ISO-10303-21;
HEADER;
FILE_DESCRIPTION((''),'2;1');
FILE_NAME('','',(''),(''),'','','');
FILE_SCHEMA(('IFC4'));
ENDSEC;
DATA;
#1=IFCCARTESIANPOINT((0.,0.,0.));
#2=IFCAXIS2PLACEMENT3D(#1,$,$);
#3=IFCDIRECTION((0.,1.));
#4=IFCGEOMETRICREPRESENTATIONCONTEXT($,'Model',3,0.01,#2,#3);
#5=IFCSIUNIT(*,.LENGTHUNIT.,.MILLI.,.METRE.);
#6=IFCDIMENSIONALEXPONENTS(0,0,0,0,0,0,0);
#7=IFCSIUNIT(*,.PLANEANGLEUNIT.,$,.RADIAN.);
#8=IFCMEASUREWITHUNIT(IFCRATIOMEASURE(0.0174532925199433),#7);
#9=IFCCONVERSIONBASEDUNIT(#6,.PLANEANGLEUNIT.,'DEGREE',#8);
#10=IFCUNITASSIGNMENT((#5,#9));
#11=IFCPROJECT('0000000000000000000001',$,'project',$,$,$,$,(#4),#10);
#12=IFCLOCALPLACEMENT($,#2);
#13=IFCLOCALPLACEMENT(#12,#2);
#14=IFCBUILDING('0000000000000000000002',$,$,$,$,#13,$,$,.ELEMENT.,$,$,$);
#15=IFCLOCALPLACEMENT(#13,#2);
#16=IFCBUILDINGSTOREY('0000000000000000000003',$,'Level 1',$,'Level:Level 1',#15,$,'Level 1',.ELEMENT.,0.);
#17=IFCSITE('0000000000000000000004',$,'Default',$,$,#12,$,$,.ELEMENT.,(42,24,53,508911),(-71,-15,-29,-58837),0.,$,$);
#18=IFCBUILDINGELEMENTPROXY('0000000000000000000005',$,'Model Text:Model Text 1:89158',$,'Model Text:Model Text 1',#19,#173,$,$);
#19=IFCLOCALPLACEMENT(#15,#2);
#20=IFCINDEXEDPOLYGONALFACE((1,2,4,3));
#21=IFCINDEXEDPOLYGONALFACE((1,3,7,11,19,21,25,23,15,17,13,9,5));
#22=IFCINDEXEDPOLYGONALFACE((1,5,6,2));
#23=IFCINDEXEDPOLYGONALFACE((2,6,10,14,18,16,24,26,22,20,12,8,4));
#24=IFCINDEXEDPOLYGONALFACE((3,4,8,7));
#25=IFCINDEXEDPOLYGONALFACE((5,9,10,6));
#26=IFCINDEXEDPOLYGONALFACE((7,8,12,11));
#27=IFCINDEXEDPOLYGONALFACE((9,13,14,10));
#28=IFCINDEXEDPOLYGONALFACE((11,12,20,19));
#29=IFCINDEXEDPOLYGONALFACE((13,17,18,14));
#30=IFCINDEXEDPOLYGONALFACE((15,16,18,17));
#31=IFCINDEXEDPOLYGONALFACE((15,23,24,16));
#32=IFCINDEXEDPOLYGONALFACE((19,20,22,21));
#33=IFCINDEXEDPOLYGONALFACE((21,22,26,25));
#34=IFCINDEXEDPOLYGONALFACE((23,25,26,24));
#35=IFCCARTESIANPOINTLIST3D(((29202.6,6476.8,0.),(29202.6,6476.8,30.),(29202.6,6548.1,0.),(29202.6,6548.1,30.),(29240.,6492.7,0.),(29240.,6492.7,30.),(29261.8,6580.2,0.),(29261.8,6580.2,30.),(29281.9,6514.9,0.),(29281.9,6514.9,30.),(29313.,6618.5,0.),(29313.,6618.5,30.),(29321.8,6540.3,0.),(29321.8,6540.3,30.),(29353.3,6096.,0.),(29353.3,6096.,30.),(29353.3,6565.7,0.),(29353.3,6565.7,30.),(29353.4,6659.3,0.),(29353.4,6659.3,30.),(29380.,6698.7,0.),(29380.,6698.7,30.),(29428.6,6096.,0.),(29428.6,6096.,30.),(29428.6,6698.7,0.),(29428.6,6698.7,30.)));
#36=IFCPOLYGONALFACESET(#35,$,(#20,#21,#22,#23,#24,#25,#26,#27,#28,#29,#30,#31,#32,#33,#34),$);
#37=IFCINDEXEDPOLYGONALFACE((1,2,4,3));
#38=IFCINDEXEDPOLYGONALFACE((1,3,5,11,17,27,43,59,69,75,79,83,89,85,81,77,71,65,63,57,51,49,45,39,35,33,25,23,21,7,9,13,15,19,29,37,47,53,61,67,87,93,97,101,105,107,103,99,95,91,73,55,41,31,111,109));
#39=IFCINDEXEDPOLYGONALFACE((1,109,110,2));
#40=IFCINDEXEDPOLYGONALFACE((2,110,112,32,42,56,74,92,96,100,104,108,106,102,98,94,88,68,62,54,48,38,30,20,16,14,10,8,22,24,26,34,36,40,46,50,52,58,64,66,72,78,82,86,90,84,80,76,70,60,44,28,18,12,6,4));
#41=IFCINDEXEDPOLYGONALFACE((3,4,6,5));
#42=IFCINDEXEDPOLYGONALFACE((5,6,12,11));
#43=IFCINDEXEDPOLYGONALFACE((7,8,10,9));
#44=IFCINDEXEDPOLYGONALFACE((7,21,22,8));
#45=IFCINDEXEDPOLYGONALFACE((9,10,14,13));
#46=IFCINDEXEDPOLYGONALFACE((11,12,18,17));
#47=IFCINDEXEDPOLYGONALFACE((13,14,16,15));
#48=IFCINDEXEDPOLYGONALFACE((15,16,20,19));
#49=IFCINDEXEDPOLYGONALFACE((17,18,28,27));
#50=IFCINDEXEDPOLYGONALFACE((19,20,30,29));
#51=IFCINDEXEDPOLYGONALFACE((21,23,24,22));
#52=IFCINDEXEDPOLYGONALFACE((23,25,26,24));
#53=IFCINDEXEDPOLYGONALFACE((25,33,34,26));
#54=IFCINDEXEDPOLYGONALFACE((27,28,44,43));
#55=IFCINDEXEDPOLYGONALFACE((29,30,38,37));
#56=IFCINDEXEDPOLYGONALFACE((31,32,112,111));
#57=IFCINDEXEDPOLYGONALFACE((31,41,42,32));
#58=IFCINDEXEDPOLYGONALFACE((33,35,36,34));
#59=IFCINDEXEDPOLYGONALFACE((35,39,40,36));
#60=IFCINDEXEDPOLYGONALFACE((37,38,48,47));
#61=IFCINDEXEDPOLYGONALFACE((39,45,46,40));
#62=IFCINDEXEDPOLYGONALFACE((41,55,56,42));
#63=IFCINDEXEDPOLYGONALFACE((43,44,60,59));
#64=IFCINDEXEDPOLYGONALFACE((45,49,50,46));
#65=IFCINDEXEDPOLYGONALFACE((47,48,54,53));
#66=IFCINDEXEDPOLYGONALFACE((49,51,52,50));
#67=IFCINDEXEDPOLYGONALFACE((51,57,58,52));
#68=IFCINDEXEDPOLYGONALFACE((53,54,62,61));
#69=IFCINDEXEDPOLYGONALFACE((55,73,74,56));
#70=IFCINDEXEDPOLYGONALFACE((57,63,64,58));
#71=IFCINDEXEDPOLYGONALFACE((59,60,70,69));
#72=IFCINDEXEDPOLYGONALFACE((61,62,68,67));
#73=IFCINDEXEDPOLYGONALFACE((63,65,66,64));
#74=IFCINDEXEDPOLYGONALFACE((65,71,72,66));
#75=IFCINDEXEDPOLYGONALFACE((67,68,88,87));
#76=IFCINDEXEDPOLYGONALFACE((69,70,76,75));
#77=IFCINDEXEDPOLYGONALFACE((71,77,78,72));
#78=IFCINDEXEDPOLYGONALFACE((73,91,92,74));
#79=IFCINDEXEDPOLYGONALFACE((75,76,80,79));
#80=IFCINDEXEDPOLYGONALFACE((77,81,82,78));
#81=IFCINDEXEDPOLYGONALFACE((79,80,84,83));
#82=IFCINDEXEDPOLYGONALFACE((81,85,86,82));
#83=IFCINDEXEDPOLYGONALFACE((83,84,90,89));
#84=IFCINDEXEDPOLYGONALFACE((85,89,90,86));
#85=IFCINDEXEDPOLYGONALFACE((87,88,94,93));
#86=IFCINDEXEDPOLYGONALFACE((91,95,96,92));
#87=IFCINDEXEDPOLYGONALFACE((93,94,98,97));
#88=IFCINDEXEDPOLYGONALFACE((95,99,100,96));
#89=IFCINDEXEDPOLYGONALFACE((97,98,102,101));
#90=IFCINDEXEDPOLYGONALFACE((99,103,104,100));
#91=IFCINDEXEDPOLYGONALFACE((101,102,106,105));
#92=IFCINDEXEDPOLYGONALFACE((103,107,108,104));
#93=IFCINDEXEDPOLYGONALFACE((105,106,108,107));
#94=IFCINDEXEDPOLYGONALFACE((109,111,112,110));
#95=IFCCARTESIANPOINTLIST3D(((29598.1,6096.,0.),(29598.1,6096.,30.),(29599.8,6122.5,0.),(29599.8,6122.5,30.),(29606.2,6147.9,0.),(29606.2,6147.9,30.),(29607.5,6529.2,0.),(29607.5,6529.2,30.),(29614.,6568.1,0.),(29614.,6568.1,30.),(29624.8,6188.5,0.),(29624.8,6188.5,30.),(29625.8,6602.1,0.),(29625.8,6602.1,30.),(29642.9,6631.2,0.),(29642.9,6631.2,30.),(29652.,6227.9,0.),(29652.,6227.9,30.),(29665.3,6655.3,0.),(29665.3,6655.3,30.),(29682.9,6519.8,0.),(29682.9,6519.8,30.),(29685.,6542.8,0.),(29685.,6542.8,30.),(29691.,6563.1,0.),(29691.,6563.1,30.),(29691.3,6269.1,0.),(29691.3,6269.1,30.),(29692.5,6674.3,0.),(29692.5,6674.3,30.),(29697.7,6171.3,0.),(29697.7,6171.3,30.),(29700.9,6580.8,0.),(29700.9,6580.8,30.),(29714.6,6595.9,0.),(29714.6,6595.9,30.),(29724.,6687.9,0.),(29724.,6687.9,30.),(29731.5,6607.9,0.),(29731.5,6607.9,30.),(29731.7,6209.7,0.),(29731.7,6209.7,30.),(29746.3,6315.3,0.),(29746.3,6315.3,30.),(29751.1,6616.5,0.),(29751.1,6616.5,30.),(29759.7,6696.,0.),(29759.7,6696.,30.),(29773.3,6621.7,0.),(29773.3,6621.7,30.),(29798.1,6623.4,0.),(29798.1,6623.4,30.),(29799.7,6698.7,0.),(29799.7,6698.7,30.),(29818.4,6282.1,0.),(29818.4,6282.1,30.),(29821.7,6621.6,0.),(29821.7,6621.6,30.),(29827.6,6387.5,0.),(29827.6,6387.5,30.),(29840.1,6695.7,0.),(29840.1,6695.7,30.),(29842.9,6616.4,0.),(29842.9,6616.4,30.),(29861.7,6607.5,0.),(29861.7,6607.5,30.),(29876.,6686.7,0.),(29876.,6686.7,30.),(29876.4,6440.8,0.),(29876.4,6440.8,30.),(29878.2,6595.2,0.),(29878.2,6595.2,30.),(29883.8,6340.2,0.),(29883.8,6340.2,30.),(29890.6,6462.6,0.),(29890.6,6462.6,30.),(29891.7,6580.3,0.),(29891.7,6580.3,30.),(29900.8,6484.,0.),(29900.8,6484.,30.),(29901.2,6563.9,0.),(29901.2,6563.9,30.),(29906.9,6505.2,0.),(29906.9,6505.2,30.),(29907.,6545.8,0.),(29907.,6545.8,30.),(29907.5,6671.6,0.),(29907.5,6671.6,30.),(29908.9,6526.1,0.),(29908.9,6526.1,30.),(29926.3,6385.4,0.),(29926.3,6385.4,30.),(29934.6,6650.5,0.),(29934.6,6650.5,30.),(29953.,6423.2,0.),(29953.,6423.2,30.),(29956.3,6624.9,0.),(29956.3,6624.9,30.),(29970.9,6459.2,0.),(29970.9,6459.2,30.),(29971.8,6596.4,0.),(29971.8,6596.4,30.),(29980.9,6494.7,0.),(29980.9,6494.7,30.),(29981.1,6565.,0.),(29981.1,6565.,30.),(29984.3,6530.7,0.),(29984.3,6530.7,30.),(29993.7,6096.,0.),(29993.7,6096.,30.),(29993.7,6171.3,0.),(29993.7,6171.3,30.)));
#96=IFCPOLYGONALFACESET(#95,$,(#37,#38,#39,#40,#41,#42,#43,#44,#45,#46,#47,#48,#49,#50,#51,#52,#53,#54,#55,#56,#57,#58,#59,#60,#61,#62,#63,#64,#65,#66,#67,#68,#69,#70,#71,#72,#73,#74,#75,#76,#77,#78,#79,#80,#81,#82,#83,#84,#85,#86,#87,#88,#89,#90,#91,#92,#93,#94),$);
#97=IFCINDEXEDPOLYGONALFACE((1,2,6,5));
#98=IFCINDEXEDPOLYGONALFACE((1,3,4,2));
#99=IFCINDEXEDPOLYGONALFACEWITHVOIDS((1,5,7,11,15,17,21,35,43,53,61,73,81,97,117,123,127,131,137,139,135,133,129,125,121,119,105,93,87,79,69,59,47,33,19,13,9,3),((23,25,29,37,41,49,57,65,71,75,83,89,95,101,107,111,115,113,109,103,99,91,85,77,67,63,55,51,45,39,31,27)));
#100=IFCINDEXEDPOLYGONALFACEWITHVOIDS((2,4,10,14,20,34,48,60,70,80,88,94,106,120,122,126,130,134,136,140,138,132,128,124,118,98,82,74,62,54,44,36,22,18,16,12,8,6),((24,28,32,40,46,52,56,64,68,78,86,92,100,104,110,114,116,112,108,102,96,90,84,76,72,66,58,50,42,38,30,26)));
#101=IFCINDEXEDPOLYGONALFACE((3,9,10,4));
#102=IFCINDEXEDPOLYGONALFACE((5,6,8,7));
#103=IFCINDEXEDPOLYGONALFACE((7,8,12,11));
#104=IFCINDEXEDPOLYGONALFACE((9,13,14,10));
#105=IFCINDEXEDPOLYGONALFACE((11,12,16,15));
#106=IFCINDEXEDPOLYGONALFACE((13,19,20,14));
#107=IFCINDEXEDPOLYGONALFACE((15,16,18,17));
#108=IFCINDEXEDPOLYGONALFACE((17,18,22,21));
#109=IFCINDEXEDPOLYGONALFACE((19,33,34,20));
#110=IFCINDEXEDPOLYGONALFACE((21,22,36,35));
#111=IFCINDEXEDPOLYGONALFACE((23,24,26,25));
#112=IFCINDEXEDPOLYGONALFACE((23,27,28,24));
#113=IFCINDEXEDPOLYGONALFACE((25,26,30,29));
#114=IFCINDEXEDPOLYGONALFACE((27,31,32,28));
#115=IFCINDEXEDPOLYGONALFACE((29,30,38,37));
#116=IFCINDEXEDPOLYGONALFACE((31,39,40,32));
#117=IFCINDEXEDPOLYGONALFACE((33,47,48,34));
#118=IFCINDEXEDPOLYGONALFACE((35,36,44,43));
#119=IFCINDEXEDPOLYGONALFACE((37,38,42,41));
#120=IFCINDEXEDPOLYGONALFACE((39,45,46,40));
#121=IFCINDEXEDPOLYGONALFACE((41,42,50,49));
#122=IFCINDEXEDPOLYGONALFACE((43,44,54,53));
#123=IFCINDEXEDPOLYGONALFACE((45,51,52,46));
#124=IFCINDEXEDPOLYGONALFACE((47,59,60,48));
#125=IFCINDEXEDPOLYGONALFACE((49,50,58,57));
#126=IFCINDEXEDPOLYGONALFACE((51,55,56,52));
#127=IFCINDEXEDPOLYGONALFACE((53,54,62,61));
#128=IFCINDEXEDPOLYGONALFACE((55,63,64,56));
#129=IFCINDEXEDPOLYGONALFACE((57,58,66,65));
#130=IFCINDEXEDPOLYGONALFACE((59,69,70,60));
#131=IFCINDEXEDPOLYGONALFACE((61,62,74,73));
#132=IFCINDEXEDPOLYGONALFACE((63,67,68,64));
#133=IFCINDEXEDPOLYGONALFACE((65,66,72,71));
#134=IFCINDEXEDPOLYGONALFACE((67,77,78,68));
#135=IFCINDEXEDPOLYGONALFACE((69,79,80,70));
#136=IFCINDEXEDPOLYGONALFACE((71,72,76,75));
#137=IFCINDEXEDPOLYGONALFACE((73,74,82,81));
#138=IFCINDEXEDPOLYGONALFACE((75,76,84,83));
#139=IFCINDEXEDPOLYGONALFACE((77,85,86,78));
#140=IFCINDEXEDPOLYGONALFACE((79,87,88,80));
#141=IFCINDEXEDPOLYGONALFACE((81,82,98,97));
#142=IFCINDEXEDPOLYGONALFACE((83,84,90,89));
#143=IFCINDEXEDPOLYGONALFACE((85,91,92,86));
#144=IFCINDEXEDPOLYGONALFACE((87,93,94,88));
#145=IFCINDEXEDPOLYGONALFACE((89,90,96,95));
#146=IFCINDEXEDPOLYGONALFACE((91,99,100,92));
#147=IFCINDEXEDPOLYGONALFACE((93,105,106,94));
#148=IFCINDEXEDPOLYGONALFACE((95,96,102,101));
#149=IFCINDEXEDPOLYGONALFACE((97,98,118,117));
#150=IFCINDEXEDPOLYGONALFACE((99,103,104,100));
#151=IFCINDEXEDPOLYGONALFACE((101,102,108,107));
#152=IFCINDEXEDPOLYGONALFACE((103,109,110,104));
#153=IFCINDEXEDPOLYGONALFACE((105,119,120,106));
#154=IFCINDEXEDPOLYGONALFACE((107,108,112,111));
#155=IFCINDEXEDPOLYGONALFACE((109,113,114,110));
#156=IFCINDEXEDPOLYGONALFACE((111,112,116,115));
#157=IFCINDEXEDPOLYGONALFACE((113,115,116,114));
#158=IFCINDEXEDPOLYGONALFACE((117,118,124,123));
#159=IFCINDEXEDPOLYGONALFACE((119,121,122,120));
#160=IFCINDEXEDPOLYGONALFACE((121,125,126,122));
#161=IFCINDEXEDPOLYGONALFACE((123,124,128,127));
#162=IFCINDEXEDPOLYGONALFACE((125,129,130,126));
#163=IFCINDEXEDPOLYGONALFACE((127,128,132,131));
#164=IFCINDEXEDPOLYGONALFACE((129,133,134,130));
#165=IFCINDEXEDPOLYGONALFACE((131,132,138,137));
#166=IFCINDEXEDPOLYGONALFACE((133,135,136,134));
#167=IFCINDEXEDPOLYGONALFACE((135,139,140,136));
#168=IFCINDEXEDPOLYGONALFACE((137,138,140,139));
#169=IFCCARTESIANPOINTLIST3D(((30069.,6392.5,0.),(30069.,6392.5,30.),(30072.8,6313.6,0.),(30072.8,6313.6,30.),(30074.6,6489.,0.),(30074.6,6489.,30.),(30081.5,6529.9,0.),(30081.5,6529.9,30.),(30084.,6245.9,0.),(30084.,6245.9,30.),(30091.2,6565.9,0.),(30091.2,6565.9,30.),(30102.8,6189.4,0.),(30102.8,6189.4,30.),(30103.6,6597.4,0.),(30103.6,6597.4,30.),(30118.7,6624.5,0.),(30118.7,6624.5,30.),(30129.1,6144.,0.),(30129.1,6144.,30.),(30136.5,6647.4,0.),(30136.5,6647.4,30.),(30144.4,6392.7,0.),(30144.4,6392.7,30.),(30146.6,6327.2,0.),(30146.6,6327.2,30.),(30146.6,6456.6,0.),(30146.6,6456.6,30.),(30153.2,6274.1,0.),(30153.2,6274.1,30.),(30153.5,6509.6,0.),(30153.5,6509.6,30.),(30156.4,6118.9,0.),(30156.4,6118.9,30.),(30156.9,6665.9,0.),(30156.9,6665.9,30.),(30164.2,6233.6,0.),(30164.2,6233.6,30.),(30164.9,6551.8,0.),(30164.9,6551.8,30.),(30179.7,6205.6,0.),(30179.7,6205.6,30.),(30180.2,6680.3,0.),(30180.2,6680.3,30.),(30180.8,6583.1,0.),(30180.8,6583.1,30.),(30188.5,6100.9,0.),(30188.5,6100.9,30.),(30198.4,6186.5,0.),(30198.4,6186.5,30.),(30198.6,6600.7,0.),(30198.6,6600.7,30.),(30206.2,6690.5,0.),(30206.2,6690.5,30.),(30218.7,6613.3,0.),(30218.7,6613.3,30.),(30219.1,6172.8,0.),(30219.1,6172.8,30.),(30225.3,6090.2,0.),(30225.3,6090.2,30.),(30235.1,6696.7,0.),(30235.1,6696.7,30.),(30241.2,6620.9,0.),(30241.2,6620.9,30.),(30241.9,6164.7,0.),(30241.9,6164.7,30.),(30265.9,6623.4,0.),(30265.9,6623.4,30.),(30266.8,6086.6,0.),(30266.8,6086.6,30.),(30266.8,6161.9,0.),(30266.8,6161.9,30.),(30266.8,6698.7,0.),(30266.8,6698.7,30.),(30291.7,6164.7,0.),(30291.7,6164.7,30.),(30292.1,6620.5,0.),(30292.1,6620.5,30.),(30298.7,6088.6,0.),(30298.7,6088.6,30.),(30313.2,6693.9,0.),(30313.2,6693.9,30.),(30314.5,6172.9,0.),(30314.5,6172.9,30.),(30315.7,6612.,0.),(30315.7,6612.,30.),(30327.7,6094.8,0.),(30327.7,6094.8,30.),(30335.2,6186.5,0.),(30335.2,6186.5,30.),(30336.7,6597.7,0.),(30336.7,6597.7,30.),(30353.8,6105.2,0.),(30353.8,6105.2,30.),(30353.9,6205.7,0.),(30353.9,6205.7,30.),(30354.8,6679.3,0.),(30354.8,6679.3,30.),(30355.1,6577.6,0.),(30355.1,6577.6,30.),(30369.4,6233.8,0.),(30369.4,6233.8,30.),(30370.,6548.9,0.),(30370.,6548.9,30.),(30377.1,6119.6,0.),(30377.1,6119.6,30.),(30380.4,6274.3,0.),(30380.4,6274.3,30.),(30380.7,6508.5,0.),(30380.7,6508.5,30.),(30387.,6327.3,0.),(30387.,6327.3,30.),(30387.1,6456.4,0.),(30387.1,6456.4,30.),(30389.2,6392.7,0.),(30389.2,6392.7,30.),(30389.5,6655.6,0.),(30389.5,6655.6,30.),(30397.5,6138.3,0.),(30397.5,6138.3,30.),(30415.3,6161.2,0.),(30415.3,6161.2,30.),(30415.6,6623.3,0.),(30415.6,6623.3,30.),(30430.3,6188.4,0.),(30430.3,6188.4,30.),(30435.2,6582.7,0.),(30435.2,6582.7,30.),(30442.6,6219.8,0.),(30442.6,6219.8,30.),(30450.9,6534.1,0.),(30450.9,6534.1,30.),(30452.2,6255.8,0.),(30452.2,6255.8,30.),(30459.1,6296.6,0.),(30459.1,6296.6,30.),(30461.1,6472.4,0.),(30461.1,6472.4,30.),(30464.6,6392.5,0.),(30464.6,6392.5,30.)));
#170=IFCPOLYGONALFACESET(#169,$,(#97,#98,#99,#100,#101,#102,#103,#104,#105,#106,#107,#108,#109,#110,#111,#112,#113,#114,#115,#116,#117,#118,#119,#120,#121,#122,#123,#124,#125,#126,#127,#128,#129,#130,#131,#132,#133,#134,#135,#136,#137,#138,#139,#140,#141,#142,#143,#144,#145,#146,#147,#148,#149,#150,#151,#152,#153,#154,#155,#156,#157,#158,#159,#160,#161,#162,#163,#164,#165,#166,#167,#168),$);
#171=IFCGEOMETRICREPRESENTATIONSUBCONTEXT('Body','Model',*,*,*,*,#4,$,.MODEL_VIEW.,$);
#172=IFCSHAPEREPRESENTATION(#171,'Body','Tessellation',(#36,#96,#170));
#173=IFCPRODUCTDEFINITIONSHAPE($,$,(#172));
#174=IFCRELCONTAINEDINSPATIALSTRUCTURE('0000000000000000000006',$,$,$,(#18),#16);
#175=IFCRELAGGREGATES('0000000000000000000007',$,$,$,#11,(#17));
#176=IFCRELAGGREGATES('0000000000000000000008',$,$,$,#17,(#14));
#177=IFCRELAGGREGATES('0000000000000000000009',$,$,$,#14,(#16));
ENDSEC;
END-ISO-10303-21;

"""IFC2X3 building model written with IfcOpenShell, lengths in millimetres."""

from ifc_helpers import new_model, entity, si_unit, converted_unit, direction, frame, origin, place, context, subcontext, project, spatial, polyline, outline, extrude, element, save


model = new_model("IFC2X3")

# Units and contexts
model_context = context("Model", 3, precision=0.01, world=origin(), true_north=direction((0.0, 1.0)))
body_context = subcontext(model_context, "Body", "Model", "MODEL_VIEW")
ifc_project = project(units=[si_unit("LENGTHUNIT", "METRE", prefix="MILLI"), converted_unit("PLANEANGLEUNIT", "DEGREE", entity("IfcRatioMeasure", 0.0174532925199433), si_unit("PLANEANGLEUNIT", "RADIAN"), dimensions=[0, 0, 0, 0, 0, 0, 0])], contexts=[model_context])

# Site, building, storey
site_placement = place(None, origin())
site = spatial("IfcSite", under=ifc_project, at=site_placement, Name="Default", CompositionType="ELEMENT", RefLatitude=(42, 24, 53, 508911), RefLongitude=(-71, -15, -29, -58837), RefElevation=0.0)
building_placement = place(site_placement, origin())
building = spatial("IfcBuilding", under=site, at=building_placement, CompositionType="ELEMENT")
storey_placement = place(building_placement, origin())
storey = spatial("IfcBuildingStorey", under=building, at=storey_placement, Name="Level 1", ObjectType="Level:Level 1", LongName="Level 1", CompositionType="ELEMENT", Elevation=0.0)

# Building element proxy
proxy_1_placement = place(storey_placement, origin())
element("IfcBuildingElementProxy", 1, at=proxy_1_placement, inside=storey, Name="Model Text:Model Text 1:89158", ObjectType="Model Text:Model Text 1", context=body_context, shape_type="SweptSolid", body=[
    extrude(outline(polyline([(-410.6, -111.6), (192.1, -111.6), (192.1, -63.1), (152.7, -36.4), (111.9, 4.0), (73.6, 55.2), (41.4, 114.4), (-29.8, 114.4), (-13.9, 77.0), (8.3, 35.1), (33.7, -4.8), (59.1, -36.3), (-410.6, -36.3), (-410.6, -111.6)])), frame((29317.0, 6506.6, 0.0), z_axis=(0.0, 0.0, 1.0), x_axis=(0.0, 1.0, 0.0)), (0.0, 0.0, 1.0), 30.0),
    extrude(outline(polyline([(-190.2, -317.5), (-190.2, -392.8), (205.4, -392.8), (203.7, -366.3), (197.3, -340.9), (178.7, -300.3), (151.5, -260.9), (112.2, -219.7), (57.2, -173.6), (-24.1, -101.3), (-72.9, -48.0), (-87.1, -26.3), (-97.3, -4.8), (-103.4, 16.4), (-105.4, 37.3), (-103.5, 57.0), (-97.7, 75.0), (-88.2, 91.5), (-74.7, 106.4), (-58.2, 118.7), (-39.4, 127.5), (-18.2, 132.8), (5.4, 134.6), (30.2, 132.9), (52.4, 127.7), (72.0, 119.1), (88.9, 107.1), (102.6, 92.0), (112.5, 74.3), (118.5, 54.0), (120.6, 31.0), (196.0, 40.4), (189.5, 79.3), (177.7, 113.3), (160.6, 142.4), (138.2, 166.5), (111.0, 185.5), (79.5, 199.1), (43.8, 207.2), (3.8, 209.9), (-36.6, 206.9), (-72.5, 197.9), (-104.0, 182.8), (-131.1, 161.7), (-152.8, 136.1), (-168.3, 107.6), (-177.6, 76.2), (-180.8, 41.9), (-177.4, 5.8), (-167.4, -29.6), (-149.5, -65.6), (-122.8, -103.4), (-80.3, -148.6), (-14.9, -206.7), (71.8, -279.1), (105.8, -317.5), (-190.2, -317.5)])), frame((29803.5, 6488.8, 0.0), z_axis=(0.0, 0.0, -1.0), x_axis=(-1.0, 0.0, 0.0)), (0.0, 0.0, -1.0), 30.0),
    extrude(outline(polyline([(-10.6, -198.7), (68.3, -198.7), (136.5, -190.7), (193.9, -174.7), (240.5, -150.6), (266.9, -124.4), (286.3, -93.2), (298.8, -57.0), (304.3, -15.7), (303.8, 16.2), (299.0, 45.5), (289.9, 72.1), (276.6, 96.0), (258.9, 117.3), (236.9, 136.2), (210.4, 152.5), (179.6, 166.3), (144.1, 177.6), (103.7, 186.3), (8.2, 196.4), (-71.8, 196.7), (-134.0, 189.4), (-183.3, 176.1), (-224.7, 158.4), (-258.2, 133.9), (-283.5, 100.3), (-300.1, 59.5), (-307.1, 13.4), (-306.6, -18.4), (-301.8, -47.5), (-292.8, -74.0), (-279.6, -97.9), (-262.0, -119.2), (-240.0, -138.1), (-213.6, -154.5), (-182.8, -168.4), (-147.3, -179.8), (-106.7, -188.6), (-10.6, -198.7)]), holes=[polyline([(-7.2, -123.5), (-71.0, -118.2), (-123.6, -108.8), (-165.2, -95.4), (-195.7, -78.0), (-212.4, -59.4), (-224.1, -38.7), (-230.6, -15.9), (-231.9, 8.9), (-227.8, 35.0), (-218.1, 58.1), (-202.8, 78.4), (-182.0, 95.8), (-152.6, 109.4), (-111.7, 118.1), (-59.4, 122.0), (4.4, 121.1), (69.6, 115.8), (122.2, 106.7), (162.2, 93.7), (189.5, 77.0), (207.7, 57.4), (220.4, 36.0), (227.5, 12.8), (229.1, -12.1), (225.2, -36.8), (215.9, -59.2), (201.3, -79.3), (181.4, -97.1), (152.6, -111.2), (111.6, -120.3), (58.3, -124.4), (-7.2, -123.5)])]), frame((30268.0, 6391.3, 0.0), z_axis=(0.0, 0.0, 1.0), x_axis=(0.047515, -0.998871, 0.0)), (0.0, 0.0, 1.0), 30.0),
])

save(model, "model.ifc")
